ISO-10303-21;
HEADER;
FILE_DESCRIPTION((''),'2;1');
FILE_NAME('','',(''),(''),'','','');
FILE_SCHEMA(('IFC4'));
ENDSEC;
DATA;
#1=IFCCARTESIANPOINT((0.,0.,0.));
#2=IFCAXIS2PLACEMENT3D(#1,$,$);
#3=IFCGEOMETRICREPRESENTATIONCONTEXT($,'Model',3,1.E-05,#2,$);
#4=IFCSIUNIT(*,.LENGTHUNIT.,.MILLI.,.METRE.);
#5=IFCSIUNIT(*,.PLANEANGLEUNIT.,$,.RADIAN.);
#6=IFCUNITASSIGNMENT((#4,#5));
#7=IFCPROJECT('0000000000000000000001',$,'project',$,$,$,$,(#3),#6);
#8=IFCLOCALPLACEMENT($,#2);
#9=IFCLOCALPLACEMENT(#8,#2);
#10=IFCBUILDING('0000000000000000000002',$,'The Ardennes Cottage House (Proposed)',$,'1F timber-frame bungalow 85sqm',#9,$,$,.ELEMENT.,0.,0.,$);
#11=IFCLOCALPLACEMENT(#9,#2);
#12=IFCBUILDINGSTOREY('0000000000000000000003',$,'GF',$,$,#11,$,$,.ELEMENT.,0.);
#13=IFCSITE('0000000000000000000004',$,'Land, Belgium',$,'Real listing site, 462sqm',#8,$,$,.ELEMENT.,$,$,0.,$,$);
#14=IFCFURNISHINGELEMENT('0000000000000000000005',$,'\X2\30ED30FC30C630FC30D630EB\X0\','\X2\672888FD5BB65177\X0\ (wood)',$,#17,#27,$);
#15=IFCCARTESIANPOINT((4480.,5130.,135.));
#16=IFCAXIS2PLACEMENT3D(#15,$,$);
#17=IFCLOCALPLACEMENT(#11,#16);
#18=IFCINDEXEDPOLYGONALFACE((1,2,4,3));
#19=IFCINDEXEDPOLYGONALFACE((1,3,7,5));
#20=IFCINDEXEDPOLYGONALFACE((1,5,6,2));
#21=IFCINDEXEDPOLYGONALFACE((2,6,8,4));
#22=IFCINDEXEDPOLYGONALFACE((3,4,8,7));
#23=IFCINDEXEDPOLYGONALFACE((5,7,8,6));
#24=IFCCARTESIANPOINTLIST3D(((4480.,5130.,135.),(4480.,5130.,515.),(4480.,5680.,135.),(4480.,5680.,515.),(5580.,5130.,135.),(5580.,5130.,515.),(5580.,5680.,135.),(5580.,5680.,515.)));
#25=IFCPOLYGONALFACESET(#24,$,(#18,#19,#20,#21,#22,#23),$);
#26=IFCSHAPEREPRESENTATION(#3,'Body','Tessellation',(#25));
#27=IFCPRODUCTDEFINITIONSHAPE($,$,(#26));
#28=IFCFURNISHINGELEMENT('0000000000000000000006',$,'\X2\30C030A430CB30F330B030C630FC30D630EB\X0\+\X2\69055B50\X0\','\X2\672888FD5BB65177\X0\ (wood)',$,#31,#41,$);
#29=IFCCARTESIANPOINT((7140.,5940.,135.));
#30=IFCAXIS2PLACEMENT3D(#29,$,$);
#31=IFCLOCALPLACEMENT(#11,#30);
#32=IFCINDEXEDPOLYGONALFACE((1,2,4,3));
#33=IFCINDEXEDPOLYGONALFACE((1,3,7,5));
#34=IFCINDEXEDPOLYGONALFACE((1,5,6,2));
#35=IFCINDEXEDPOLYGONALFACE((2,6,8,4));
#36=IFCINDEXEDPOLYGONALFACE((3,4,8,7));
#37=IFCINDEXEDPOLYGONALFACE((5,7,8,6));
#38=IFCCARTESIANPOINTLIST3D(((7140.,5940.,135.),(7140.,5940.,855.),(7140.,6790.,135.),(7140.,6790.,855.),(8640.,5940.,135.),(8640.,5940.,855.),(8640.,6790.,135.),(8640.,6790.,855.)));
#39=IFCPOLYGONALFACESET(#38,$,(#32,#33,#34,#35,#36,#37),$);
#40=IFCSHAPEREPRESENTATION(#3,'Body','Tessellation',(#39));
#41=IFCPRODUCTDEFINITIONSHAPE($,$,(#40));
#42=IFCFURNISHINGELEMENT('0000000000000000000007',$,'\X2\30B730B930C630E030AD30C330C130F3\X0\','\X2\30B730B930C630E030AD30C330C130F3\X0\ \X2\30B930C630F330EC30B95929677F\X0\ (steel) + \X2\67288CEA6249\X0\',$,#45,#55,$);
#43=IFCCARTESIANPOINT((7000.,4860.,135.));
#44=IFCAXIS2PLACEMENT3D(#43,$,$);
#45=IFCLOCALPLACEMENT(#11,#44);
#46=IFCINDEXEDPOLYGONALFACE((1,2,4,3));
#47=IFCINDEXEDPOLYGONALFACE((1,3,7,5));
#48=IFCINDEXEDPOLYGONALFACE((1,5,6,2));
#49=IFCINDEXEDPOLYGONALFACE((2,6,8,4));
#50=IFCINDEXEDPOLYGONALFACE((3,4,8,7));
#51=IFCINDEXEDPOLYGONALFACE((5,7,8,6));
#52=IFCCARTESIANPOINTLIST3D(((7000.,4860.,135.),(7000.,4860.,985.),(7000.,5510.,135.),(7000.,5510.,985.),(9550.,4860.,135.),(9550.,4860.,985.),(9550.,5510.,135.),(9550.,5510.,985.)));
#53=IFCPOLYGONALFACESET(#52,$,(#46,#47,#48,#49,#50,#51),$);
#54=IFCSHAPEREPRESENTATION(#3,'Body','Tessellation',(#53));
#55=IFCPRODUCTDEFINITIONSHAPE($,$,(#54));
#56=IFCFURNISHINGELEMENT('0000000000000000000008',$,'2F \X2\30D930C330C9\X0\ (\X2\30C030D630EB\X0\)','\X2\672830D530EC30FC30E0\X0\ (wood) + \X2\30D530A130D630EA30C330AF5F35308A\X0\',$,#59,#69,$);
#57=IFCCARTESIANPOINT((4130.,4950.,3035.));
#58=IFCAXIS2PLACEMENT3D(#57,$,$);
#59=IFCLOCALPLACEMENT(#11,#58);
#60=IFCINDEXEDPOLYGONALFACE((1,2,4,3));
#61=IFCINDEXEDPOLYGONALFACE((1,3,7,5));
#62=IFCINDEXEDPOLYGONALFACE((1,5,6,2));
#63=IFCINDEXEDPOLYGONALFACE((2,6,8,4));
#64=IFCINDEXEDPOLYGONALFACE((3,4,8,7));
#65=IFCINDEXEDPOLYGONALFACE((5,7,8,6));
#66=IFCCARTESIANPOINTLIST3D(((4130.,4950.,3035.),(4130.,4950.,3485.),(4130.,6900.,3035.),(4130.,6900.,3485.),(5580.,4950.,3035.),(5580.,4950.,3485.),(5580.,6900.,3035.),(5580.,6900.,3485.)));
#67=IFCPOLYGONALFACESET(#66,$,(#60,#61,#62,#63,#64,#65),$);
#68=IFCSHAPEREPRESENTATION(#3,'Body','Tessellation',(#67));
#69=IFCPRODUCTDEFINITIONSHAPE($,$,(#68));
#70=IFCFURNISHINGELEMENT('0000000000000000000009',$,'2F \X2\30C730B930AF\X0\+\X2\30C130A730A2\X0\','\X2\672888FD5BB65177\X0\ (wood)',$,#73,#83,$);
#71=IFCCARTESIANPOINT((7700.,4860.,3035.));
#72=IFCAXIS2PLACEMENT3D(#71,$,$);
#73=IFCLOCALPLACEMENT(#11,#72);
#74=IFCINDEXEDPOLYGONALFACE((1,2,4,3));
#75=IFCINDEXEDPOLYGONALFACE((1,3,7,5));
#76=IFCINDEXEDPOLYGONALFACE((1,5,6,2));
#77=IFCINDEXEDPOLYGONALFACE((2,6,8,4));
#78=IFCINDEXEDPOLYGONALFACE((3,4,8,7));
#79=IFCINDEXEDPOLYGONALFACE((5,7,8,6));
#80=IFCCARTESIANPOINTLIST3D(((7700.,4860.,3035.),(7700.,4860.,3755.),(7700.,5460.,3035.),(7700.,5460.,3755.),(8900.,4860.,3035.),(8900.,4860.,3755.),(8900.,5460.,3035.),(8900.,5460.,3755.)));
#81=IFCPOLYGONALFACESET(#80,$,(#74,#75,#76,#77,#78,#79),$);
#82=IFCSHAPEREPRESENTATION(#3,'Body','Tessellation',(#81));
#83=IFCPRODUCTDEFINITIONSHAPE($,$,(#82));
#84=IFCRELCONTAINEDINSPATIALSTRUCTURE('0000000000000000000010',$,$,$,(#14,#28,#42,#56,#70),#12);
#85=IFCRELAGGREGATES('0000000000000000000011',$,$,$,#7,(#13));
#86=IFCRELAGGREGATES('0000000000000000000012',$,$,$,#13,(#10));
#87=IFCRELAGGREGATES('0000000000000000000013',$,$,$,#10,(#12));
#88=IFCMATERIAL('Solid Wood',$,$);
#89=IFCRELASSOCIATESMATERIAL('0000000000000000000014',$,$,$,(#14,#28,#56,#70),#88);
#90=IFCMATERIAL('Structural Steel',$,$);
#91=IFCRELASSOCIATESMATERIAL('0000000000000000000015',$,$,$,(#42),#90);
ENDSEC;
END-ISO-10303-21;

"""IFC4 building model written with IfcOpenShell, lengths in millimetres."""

from ifc_helpers import new_model, si_unit, frame, frame_2d, origin, place, context, project, spatial, rectangle, extrude, material, element, save


model = new_model("IFC4")

# Units and contexts
model_context = context("Model", 3, precision=1e-05, world=origin())
ifc_project = project(units=[si_unit("LENGTHUNIT", "METRE", prefix="MILLI"), si_unit("PLANEANGLEUNIT", "RADIAN")], contexts=[model_context])

# Site, building, storey
site_placement = place(None, origin())
site = spatial("IfcSite", under=ifc_project, at=site_placement, Name="Land, Belgium", ObjectType="Real listing site, 462sqm", CompositionType="ELEMENT", RefElevation=0.0)
building_placement = place(site_placement, origin())
building = spatial("IfcBuilding", under=site, at=building_placement, Name="The Ardennes Cottage House (Proposed)", ObjectType="1F timber-frame bungalow 85sqm", CompositionType="ELEMENT", ElevationOfRefHeight=0.0, ElevationOfTerrain=0.0)
storey_placement = place(building_placement, origin())
storey = spatial("IfcBuildingStorey", under=building, at=storey_placement, Name="GF", CompositionType="ELEMENT", Elevation=0.0)

# Shared definitions
ifc_material_1 = material(Name="Solid Wood")

# Shared definitions
ifc_material_2 = material(Name="Structural Steel")

# Furnishing elements
furnishing_1_placement = place(storey_placement, frame((4480.0, 5130.0, 135.0)))
element("IfcFurnishingElement", 1, at=furnishing_1_placement, inside=storey, material=ifc_material_1, Name="ローテーブル", Description="木製家具 (wood)", context=model_context, shape_type="SweptSolid", body=[
    extrude(rectangle(XDim=1100.0, YDim=550.0, at=frame_2d((550.0, 275.0))), frame((4480.0, 5130.0, 135.0)), (0.0, 0.0, 1.0), 380.0),
])
furnishing_2_placement = place(storey_placement, frame((7140.0, 5940.0, 135.0)))
element("IfcFurnishingElement", 2, at=furnishing_2_placement, inside=storey, material=ifc_material_1, Name="ダイニングテーブル+椅子", Description="木製家具 (wood)", context=model_context, shape_type="SweptSolid", body=[
    extrude(rectangle(XDim=1500.0, YDim=850.0, at=frame_2d((750.0, 425.0))), frame((7140.0, 5940.0, 135.0)), (0.0, 0.0, 1.0), 720.0),
])
furnishing_3_placement = place(storey_placement, frame((7000.0, 4860.0, 135.0)))
element("IfcFurnishingElement", 3, at=furnishing_3_placement, inside=storey, material=ifc_material_2, Name="システムキッチン", Description="システムキッチン ステンレス天板 (steel) + 木質扉", context=model_context, shape_type="SweptSolid", body=[
    extrude(rectangle(XDim=2550.0, YDim=650.0, at=frame_2d((1275.0, 325.0))), frame((7000.0, 4860.0, 135.0)), (0.0, 0.0, 1.0), 850.0),
])
furnishing_4_placement = place(storey_placement, frame((4130.0, 4950.0, 3035.0)))
element("IfcFurnishingElement", 4, at=furnishing_4_placement, inside=storey, material=ifc_material_1, Name="2F ベッド (ダブル)", Description="木フレーム (wood) + ファブリック張り", context=model_context, shape_type="SweptSolid", body=[
    extrude(rectangle(XDim=1450.0, YDim=1950.0, at=frame_2d((725.0, 975.0))), frame((4130.0, 4950.0, 3035.0)), (0.0, 0.0, 1.0), 450.0),
])
furnishing_5_placement = place(storey_placement, frame((7700.0, 4860.0, 3035.0)))
element("IfcFurnishingElement", 5, at=furnishing_5_placement, inside=storey, material=ifc_material_1, Name="2F デスク+チェア", Description="木製家具 (wood)", context=model_context, shape_type="SweptSolid", body=[
    extrude(rectangle(XDim=1200.0, YDim=600.0, at=frame_2d((600.0, 300.0))), frame((7700.0, 4860.0, 3035.0)), (0.0, 0.0, 1.0), 720.0),
])

save(model, "model.ifc")
